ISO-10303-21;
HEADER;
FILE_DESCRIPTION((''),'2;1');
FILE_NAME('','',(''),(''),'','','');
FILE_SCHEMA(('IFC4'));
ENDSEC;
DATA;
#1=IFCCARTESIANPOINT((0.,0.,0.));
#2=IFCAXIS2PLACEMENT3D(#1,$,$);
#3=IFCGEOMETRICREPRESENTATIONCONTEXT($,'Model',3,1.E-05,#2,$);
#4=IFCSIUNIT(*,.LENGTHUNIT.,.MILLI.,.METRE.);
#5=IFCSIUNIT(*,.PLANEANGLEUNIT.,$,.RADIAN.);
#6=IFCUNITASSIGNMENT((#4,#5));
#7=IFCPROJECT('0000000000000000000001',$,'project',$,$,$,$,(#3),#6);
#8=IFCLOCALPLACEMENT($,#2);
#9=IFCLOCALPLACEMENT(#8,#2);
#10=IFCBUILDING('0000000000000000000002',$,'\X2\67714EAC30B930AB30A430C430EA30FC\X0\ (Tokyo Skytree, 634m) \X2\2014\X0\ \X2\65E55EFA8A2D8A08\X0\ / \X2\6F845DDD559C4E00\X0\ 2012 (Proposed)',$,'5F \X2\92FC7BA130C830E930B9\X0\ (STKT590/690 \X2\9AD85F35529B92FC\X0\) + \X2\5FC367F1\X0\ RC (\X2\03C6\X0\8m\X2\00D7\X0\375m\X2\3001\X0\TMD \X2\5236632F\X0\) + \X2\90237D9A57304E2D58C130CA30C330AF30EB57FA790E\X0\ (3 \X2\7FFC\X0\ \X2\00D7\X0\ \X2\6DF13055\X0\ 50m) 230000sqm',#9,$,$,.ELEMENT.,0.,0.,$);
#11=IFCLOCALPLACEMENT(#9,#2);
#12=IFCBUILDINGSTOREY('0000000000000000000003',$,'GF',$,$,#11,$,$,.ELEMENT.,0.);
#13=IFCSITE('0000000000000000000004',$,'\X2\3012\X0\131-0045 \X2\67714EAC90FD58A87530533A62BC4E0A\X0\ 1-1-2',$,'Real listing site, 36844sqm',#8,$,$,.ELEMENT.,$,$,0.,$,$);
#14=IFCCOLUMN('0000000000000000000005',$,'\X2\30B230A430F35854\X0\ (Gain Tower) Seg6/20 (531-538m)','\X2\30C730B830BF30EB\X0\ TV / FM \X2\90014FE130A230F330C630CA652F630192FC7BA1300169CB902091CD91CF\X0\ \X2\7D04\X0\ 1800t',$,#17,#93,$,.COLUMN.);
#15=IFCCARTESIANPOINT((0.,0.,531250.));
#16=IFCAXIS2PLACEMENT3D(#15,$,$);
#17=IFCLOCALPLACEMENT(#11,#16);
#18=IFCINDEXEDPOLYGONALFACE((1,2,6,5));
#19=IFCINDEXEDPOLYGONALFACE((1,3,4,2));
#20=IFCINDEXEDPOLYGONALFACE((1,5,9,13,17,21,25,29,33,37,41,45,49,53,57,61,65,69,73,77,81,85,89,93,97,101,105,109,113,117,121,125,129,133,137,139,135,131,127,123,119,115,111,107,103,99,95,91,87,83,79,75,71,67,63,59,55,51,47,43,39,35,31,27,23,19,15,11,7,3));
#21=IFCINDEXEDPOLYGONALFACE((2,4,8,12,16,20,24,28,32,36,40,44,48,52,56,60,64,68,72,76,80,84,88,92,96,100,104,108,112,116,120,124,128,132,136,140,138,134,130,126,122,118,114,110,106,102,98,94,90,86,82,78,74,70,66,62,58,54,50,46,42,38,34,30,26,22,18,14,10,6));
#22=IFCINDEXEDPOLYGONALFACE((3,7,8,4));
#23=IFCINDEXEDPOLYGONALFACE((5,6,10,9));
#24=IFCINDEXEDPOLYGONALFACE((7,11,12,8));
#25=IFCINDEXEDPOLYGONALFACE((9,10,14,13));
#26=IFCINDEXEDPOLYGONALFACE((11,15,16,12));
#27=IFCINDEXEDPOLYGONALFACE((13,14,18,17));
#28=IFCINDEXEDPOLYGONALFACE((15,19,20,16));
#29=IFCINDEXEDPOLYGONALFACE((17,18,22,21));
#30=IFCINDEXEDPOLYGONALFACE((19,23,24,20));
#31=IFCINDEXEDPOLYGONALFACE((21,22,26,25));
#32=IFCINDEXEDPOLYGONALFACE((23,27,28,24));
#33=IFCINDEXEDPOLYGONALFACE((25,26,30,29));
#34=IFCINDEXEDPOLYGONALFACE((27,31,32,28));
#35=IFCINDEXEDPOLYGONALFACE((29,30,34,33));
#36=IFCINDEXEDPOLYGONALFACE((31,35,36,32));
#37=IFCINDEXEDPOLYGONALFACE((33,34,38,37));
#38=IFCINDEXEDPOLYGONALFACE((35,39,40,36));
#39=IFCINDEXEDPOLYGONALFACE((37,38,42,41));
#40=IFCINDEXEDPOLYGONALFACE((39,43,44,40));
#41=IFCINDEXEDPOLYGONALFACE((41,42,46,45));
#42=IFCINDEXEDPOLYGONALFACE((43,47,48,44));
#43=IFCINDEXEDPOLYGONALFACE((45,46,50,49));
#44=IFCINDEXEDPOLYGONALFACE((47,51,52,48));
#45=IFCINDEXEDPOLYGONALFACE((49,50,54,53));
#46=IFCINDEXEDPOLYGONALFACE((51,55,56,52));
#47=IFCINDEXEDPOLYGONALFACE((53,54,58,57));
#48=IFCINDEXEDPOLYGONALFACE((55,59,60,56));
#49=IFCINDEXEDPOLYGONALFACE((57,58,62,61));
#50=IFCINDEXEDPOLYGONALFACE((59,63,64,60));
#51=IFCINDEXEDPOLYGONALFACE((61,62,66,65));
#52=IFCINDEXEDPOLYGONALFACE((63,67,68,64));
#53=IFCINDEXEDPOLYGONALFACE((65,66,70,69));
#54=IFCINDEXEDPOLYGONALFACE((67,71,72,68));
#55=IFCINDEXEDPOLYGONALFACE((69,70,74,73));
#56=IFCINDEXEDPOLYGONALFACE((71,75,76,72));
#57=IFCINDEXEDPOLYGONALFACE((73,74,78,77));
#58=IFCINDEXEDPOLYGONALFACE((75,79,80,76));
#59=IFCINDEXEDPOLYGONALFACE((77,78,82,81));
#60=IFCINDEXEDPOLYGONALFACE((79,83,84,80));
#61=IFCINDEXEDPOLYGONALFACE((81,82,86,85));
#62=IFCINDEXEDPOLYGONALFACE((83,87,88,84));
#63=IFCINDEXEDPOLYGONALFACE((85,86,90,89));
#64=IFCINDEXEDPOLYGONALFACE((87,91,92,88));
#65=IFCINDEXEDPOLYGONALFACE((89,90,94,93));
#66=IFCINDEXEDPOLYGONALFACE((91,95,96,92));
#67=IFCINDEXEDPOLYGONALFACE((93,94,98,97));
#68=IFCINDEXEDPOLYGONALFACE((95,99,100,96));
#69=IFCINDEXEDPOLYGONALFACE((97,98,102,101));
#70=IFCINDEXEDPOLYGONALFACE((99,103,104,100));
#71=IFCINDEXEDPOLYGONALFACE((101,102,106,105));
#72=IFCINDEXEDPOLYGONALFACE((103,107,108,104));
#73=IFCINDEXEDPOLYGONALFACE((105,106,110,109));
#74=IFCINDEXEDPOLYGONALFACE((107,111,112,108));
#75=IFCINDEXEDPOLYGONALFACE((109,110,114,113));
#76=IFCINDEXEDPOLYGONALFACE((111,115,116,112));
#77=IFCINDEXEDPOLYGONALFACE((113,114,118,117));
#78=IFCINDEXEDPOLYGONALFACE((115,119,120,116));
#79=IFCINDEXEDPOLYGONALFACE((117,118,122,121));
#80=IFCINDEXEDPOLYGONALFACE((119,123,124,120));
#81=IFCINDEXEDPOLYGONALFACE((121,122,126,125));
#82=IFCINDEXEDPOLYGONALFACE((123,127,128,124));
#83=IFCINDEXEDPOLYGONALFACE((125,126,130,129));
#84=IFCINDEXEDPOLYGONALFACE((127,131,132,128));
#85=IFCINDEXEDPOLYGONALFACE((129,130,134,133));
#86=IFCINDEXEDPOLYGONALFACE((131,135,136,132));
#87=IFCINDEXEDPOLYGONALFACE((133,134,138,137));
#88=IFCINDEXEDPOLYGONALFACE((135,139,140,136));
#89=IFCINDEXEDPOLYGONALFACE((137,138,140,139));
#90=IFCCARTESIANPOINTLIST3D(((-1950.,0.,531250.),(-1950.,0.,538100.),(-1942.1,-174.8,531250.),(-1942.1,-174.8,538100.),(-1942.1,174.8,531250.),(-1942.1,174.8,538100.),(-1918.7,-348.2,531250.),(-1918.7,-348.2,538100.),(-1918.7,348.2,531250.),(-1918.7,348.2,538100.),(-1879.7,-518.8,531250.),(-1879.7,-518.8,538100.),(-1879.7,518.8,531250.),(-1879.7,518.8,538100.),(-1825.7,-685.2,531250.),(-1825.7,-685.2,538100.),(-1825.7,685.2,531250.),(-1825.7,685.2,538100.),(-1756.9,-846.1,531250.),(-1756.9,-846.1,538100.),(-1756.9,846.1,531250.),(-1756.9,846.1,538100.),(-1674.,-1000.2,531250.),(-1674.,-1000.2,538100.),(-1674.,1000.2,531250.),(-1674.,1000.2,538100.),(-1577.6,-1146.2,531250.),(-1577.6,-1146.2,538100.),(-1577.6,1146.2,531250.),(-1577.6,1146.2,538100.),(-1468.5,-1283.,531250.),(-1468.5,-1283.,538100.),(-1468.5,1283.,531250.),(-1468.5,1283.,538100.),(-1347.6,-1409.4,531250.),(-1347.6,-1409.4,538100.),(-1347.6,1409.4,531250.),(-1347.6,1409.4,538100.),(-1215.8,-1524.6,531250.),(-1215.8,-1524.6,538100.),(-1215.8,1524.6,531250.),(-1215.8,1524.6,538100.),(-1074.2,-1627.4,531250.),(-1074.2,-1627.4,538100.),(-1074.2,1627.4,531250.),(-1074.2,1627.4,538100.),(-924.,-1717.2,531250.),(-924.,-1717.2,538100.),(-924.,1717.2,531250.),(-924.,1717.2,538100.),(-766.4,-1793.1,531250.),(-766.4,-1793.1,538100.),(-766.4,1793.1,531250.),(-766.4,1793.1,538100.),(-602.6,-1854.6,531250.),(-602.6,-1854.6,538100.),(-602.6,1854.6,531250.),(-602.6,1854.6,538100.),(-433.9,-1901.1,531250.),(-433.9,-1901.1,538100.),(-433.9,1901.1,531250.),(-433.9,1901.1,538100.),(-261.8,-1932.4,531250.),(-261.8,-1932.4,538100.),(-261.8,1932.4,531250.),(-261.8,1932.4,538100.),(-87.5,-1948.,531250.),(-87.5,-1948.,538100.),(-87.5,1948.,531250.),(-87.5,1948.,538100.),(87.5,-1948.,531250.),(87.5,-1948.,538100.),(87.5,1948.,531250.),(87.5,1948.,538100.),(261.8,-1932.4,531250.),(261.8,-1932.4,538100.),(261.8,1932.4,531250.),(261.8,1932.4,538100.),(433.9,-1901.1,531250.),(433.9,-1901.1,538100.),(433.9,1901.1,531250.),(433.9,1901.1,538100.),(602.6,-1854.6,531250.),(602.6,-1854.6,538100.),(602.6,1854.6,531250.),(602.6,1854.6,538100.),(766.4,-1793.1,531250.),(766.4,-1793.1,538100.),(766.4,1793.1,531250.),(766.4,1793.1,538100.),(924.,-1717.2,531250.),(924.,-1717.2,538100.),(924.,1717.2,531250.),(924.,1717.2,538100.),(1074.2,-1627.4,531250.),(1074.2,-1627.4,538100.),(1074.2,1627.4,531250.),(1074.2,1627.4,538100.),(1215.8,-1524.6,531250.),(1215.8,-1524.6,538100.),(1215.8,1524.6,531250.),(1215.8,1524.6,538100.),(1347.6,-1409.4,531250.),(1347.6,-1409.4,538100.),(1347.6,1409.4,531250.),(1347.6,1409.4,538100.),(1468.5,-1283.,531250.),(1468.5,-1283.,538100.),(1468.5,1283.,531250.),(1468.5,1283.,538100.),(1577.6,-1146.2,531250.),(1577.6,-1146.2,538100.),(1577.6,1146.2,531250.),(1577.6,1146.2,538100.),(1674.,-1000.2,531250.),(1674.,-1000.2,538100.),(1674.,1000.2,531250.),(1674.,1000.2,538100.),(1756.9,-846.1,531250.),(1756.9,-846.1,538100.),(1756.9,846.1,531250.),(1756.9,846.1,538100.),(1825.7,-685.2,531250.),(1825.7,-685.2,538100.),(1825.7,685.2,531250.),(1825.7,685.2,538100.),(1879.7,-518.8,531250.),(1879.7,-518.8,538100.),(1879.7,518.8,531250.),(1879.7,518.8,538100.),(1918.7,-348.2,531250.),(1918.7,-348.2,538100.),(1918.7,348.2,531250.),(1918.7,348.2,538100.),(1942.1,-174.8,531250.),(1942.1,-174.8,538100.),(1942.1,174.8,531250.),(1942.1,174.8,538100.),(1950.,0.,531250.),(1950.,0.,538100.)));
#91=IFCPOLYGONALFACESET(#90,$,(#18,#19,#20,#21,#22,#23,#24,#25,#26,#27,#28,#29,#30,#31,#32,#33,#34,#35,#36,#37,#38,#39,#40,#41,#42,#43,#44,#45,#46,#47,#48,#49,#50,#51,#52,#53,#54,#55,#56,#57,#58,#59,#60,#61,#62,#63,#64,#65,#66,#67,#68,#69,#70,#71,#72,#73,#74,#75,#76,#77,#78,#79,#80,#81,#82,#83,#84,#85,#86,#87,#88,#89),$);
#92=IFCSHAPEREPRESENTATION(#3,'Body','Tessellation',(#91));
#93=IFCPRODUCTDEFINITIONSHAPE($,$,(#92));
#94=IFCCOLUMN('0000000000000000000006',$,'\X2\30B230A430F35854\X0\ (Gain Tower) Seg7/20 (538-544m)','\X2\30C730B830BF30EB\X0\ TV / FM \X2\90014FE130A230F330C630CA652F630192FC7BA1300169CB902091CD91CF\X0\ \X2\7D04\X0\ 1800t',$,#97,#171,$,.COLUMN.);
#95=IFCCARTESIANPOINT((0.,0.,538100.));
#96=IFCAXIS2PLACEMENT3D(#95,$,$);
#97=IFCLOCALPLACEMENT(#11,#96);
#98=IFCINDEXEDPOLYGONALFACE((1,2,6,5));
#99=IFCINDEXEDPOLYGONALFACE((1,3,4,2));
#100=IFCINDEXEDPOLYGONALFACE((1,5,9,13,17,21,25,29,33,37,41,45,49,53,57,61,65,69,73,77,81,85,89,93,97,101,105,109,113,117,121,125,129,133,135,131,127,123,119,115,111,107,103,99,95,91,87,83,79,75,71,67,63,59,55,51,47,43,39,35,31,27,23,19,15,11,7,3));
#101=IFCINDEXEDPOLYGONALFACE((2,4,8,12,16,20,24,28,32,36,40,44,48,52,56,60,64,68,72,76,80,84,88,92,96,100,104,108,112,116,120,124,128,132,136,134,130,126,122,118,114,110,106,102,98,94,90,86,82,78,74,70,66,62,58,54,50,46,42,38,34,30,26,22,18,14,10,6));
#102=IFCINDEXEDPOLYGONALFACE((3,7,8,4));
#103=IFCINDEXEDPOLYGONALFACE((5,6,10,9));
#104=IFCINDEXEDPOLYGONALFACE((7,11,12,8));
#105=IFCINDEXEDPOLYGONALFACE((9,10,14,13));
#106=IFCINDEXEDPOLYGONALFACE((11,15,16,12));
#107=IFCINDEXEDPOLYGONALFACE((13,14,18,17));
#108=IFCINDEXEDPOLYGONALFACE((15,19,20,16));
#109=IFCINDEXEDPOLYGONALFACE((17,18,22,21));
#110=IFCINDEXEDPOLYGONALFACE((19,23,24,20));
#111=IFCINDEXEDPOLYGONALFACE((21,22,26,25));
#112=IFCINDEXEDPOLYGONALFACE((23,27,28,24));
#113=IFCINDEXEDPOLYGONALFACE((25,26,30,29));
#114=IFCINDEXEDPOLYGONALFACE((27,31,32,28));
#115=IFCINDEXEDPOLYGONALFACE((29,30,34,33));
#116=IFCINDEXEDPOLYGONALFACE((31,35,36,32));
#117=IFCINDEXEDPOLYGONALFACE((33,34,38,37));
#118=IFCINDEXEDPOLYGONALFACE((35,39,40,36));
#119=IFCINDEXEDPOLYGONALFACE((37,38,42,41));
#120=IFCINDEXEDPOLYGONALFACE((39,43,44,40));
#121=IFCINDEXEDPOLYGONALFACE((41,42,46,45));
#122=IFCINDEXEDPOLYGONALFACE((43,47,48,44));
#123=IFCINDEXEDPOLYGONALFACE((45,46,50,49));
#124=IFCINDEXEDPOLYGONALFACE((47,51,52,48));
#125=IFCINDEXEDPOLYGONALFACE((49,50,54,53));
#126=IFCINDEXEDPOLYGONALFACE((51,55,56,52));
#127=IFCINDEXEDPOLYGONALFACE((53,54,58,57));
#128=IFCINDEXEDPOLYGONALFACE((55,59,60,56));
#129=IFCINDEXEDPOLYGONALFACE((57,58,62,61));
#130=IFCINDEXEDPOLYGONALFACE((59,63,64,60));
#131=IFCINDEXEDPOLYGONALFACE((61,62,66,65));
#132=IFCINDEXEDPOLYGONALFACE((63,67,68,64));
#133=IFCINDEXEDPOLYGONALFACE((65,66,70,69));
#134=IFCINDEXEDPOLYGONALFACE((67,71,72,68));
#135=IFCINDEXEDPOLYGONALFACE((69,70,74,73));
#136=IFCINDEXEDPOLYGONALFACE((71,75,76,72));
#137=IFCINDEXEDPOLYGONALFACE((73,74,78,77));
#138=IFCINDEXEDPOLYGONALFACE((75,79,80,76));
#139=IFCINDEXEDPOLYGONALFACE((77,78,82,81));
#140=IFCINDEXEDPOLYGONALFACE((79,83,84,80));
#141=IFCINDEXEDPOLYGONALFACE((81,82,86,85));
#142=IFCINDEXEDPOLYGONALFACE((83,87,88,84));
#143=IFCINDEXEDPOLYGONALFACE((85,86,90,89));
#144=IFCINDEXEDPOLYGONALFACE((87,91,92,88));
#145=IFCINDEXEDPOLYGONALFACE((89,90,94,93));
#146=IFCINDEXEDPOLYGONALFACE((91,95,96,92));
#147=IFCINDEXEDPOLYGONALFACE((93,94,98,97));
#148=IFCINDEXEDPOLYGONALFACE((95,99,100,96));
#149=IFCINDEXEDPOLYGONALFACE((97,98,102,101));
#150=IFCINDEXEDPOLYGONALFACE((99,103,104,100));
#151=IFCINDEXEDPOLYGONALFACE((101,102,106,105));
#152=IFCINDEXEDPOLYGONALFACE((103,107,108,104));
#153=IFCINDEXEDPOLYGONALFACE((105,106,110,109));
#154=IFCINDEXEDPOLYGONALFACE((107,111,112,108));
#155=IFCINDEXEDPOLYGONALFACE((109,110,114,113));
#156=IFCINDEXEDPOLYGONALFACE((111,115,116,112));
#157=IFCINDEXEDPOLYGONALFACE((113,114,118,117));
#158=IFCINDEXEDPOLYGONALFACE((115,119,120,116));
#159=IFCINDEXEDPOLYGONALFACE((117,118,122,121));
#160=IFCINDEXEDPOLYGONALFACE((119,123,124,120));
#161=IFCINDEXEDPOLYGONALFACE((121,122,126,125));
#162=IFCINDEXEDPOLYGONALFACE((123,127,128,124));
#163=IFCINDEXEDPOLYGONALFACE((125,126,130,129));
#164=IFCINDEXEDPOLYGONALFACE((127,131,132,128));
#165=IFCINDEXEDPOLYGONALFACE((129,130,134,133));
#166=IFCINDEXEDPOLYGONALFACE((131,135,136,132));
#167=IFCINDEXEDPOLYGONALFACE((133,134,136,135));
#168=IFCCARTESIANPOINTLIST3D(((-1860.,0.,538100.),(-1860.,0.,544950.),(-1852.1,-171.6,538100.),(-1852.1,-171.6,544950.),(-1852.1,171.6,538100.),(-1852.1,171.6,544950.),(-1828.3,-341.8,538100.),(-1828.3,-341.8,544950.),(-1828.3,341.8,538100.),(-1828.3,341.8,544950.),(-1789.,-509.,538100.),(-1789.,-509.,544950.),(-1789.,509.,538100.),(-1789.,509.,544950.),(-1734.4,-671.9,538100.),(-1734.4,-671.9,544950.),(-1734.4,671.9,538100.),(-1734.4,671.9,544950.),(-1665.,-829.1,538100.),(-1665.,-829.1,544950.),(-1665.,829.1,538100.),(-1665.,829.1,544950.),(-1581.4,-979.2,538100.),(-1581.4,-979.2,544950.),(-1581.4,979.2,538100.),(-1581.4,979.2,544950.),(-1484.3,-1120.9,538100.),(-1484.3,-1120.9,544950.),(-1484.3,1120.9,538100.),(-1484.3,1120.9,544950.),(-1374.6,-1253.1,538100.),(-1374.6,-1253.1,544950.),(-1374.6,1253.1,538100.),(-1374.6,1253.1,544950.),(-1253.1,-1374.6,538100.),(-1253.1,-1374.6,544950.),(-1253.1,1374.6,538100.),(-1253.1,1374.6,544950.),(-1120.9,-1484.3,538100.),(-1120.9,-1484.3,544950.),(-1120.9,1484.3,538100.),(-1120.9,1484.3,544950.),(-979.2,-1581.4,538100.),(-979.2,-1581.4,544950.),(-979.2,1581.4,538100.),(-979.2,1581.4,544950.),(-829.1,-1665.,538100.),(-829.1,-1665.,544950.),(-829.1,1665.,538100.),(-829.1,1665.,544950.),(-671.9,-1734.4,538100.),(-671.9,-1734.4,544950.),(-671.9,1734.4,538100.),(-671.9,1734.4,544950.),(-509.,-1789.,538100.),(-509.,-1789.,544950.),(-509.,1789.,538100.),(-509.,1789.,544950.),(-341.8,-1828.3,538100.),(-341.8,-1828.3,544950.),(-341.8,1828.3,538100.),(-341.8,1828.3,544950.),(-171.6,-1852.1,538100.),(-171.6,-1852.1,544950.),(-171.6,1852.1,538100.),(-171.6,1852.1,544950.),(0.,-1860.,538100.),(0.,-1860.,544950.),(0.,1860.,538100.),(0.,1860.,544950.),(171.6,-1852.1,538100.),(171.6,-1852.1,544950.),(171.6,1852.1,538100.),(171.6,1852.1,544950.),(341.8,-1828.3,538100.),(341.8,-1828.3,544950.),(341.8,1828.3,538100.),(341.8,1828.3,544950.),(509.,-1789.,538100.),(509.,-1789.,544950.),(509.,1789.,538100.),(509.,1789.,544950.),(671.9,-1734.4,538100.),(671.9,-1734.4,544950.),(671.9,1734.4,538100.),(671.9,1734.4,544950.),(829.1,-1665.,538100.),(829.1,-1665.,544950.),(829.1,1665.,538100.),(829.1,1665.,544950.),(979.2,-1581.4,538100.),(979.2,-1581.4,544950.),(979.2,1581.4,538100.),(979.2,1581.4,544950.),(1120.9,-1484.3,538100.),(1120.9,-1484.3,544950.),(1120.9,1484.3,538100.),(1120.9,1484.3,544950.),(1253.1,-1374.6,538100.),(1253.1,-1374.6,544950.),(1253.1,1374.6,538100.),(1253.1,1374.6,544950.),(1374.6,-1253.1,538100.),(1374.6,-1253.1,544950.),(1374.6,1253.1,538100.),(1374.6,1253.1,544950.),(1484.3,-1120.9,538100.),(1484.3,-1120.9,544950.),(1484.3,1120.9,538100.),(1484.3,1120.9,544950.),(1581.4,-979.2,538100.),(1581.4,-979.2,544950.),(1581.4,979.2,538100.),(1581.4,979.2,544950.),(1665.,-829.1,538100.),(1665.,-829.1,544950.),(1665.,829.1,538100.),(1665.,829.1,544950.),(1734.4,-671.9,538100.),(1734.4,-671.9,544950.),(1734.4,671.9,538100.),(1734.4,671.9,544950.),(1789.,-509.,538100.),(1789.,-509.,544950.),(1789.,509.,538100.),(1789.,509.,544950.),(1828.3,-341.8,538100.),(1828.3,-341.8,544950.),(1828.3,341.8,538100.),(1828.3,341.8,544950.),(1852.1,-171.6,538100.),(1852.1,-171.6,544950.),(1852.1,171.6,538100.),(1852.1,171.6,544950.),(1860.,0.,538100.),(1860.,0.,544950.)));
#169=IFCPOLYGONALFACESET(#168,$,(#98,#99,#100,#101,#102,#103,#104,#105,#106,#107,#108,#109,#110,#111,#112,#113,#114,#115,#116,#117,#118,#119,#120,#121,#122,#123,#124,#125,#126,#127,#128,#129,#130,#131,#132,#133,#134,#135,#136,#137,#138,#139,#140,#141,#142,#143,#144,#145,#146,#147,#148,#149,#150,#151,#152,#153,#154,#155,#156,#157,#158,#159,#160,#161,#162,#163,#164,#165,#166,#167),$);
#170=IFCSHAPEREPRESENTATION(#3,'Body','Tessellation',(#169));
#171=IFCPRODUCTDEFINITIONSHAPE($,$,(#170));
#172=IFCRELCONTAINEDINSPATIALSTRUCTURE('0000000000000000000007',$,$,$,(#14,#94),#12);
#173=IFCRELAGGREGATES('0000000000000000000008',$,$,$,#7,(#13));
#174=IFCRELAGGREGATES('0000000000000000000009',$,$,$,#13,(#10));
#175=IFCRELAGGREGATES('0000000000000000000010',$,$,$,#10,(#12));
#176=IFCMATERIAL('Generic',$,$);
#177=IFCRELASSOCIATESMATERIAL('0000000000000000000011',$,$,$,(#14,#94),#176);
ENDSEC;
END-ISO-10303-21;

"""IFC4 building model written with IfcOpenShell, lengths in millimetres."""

from ifc_helpers import new_model, si_unit, frame, origin, origin_2d, place, context, project, spatial, circle, extrude, material, element, save


model = new_model("IFC4")

# Units and contexts
model_context = context("Model", 3, precision=1e-05, world=origin())
ifc_project = project(units=[si_unit("LENGTHUNIT", "METRE", prefix="MILLI"), si_unit("PLANEANGLEUNIT", "RADIAN")], contexts=[model_context])

# Site, building, storey
site_placement = place(None, origin())
site = spatial("IfcSite", under=ifc_project, at=site_placement, Name="〒131-0045 東京都墨田区押上 1-1-2", ObjectType="Real listing site, 36844sqm", CompositionType="ELEMENT", RefElevation=0.0)
building_placement = place(site_placement, origin())
building = spatial("IfcBuilding", under=site, at=building_placement, Name="東京スカイツリー (Tokyo Skytree, 634m) — 日建設計 / 澄川喜一 2012 (Proposed)", ObjectType="5F 鋼管トラス (STKT590/690 高張力鋼) + 心柱 RC (φ8m×375m、TMD 制振) + 連続地中壁ナックル基礎 (3 翼 × 深さ 50m) 230000sqm", CompositionType="ELEMENT", ElevationOfRefHeight=0.0, ElevationOfTerrain=0.0)
storey_placement = place(building_placement, origin())
storey = spatial("IfcBuildingStorey", under=building, at=storey_placement, Name="GF", CompositionType="ELEMENT", Elevation=0.0)

# Columns
ifc_material = material(Name="Generic")
column_1_placement = place(storey_placement, frame((0.0, 0.0, 531250.0)))
element("IfcColumn", 1, at=column_1_placement, inside=storey, material=ifc_material, Name="ゲイン塔 (Gain Tower) Seg6/20 (531-538m)", Description="デジタル TV / FM 送信アンテナ支持鋼管、構造重量 約 1800t", PredefinedType="COLUMN", context=model_context, shape_type="SweptSolid", body=[
    extrude(circle(Radius=1950.0, at=origin_2d()), frame((0.0, 0.0, 531250.0)), (0.0, 0.0, 1.0), 6850.0),
])
column_2_placement = place(storey_placement, frame((0.0, 0.0, 538100.0)))
element("IfcColumn", 2, at=column_2_placement, inside=storey, material=ifc_material, Name="ゲイン塔 (Gain Tower) Seg7/20 (538-544m)", Description="デジタル TV / FM 送信アンテナ支持鋼管、構造重量 約 1800t", PredefinedType="COLUMN", context=model_context, shape_type="SweptSolid", body=[
    extrude(circle(Radius=1860.0, at=origin_2d()), frame((0.0, 0.0, 538100.0)), (0.0, 0.0, 1.0), 6850.0),
])

save(model, "model.ifc")
